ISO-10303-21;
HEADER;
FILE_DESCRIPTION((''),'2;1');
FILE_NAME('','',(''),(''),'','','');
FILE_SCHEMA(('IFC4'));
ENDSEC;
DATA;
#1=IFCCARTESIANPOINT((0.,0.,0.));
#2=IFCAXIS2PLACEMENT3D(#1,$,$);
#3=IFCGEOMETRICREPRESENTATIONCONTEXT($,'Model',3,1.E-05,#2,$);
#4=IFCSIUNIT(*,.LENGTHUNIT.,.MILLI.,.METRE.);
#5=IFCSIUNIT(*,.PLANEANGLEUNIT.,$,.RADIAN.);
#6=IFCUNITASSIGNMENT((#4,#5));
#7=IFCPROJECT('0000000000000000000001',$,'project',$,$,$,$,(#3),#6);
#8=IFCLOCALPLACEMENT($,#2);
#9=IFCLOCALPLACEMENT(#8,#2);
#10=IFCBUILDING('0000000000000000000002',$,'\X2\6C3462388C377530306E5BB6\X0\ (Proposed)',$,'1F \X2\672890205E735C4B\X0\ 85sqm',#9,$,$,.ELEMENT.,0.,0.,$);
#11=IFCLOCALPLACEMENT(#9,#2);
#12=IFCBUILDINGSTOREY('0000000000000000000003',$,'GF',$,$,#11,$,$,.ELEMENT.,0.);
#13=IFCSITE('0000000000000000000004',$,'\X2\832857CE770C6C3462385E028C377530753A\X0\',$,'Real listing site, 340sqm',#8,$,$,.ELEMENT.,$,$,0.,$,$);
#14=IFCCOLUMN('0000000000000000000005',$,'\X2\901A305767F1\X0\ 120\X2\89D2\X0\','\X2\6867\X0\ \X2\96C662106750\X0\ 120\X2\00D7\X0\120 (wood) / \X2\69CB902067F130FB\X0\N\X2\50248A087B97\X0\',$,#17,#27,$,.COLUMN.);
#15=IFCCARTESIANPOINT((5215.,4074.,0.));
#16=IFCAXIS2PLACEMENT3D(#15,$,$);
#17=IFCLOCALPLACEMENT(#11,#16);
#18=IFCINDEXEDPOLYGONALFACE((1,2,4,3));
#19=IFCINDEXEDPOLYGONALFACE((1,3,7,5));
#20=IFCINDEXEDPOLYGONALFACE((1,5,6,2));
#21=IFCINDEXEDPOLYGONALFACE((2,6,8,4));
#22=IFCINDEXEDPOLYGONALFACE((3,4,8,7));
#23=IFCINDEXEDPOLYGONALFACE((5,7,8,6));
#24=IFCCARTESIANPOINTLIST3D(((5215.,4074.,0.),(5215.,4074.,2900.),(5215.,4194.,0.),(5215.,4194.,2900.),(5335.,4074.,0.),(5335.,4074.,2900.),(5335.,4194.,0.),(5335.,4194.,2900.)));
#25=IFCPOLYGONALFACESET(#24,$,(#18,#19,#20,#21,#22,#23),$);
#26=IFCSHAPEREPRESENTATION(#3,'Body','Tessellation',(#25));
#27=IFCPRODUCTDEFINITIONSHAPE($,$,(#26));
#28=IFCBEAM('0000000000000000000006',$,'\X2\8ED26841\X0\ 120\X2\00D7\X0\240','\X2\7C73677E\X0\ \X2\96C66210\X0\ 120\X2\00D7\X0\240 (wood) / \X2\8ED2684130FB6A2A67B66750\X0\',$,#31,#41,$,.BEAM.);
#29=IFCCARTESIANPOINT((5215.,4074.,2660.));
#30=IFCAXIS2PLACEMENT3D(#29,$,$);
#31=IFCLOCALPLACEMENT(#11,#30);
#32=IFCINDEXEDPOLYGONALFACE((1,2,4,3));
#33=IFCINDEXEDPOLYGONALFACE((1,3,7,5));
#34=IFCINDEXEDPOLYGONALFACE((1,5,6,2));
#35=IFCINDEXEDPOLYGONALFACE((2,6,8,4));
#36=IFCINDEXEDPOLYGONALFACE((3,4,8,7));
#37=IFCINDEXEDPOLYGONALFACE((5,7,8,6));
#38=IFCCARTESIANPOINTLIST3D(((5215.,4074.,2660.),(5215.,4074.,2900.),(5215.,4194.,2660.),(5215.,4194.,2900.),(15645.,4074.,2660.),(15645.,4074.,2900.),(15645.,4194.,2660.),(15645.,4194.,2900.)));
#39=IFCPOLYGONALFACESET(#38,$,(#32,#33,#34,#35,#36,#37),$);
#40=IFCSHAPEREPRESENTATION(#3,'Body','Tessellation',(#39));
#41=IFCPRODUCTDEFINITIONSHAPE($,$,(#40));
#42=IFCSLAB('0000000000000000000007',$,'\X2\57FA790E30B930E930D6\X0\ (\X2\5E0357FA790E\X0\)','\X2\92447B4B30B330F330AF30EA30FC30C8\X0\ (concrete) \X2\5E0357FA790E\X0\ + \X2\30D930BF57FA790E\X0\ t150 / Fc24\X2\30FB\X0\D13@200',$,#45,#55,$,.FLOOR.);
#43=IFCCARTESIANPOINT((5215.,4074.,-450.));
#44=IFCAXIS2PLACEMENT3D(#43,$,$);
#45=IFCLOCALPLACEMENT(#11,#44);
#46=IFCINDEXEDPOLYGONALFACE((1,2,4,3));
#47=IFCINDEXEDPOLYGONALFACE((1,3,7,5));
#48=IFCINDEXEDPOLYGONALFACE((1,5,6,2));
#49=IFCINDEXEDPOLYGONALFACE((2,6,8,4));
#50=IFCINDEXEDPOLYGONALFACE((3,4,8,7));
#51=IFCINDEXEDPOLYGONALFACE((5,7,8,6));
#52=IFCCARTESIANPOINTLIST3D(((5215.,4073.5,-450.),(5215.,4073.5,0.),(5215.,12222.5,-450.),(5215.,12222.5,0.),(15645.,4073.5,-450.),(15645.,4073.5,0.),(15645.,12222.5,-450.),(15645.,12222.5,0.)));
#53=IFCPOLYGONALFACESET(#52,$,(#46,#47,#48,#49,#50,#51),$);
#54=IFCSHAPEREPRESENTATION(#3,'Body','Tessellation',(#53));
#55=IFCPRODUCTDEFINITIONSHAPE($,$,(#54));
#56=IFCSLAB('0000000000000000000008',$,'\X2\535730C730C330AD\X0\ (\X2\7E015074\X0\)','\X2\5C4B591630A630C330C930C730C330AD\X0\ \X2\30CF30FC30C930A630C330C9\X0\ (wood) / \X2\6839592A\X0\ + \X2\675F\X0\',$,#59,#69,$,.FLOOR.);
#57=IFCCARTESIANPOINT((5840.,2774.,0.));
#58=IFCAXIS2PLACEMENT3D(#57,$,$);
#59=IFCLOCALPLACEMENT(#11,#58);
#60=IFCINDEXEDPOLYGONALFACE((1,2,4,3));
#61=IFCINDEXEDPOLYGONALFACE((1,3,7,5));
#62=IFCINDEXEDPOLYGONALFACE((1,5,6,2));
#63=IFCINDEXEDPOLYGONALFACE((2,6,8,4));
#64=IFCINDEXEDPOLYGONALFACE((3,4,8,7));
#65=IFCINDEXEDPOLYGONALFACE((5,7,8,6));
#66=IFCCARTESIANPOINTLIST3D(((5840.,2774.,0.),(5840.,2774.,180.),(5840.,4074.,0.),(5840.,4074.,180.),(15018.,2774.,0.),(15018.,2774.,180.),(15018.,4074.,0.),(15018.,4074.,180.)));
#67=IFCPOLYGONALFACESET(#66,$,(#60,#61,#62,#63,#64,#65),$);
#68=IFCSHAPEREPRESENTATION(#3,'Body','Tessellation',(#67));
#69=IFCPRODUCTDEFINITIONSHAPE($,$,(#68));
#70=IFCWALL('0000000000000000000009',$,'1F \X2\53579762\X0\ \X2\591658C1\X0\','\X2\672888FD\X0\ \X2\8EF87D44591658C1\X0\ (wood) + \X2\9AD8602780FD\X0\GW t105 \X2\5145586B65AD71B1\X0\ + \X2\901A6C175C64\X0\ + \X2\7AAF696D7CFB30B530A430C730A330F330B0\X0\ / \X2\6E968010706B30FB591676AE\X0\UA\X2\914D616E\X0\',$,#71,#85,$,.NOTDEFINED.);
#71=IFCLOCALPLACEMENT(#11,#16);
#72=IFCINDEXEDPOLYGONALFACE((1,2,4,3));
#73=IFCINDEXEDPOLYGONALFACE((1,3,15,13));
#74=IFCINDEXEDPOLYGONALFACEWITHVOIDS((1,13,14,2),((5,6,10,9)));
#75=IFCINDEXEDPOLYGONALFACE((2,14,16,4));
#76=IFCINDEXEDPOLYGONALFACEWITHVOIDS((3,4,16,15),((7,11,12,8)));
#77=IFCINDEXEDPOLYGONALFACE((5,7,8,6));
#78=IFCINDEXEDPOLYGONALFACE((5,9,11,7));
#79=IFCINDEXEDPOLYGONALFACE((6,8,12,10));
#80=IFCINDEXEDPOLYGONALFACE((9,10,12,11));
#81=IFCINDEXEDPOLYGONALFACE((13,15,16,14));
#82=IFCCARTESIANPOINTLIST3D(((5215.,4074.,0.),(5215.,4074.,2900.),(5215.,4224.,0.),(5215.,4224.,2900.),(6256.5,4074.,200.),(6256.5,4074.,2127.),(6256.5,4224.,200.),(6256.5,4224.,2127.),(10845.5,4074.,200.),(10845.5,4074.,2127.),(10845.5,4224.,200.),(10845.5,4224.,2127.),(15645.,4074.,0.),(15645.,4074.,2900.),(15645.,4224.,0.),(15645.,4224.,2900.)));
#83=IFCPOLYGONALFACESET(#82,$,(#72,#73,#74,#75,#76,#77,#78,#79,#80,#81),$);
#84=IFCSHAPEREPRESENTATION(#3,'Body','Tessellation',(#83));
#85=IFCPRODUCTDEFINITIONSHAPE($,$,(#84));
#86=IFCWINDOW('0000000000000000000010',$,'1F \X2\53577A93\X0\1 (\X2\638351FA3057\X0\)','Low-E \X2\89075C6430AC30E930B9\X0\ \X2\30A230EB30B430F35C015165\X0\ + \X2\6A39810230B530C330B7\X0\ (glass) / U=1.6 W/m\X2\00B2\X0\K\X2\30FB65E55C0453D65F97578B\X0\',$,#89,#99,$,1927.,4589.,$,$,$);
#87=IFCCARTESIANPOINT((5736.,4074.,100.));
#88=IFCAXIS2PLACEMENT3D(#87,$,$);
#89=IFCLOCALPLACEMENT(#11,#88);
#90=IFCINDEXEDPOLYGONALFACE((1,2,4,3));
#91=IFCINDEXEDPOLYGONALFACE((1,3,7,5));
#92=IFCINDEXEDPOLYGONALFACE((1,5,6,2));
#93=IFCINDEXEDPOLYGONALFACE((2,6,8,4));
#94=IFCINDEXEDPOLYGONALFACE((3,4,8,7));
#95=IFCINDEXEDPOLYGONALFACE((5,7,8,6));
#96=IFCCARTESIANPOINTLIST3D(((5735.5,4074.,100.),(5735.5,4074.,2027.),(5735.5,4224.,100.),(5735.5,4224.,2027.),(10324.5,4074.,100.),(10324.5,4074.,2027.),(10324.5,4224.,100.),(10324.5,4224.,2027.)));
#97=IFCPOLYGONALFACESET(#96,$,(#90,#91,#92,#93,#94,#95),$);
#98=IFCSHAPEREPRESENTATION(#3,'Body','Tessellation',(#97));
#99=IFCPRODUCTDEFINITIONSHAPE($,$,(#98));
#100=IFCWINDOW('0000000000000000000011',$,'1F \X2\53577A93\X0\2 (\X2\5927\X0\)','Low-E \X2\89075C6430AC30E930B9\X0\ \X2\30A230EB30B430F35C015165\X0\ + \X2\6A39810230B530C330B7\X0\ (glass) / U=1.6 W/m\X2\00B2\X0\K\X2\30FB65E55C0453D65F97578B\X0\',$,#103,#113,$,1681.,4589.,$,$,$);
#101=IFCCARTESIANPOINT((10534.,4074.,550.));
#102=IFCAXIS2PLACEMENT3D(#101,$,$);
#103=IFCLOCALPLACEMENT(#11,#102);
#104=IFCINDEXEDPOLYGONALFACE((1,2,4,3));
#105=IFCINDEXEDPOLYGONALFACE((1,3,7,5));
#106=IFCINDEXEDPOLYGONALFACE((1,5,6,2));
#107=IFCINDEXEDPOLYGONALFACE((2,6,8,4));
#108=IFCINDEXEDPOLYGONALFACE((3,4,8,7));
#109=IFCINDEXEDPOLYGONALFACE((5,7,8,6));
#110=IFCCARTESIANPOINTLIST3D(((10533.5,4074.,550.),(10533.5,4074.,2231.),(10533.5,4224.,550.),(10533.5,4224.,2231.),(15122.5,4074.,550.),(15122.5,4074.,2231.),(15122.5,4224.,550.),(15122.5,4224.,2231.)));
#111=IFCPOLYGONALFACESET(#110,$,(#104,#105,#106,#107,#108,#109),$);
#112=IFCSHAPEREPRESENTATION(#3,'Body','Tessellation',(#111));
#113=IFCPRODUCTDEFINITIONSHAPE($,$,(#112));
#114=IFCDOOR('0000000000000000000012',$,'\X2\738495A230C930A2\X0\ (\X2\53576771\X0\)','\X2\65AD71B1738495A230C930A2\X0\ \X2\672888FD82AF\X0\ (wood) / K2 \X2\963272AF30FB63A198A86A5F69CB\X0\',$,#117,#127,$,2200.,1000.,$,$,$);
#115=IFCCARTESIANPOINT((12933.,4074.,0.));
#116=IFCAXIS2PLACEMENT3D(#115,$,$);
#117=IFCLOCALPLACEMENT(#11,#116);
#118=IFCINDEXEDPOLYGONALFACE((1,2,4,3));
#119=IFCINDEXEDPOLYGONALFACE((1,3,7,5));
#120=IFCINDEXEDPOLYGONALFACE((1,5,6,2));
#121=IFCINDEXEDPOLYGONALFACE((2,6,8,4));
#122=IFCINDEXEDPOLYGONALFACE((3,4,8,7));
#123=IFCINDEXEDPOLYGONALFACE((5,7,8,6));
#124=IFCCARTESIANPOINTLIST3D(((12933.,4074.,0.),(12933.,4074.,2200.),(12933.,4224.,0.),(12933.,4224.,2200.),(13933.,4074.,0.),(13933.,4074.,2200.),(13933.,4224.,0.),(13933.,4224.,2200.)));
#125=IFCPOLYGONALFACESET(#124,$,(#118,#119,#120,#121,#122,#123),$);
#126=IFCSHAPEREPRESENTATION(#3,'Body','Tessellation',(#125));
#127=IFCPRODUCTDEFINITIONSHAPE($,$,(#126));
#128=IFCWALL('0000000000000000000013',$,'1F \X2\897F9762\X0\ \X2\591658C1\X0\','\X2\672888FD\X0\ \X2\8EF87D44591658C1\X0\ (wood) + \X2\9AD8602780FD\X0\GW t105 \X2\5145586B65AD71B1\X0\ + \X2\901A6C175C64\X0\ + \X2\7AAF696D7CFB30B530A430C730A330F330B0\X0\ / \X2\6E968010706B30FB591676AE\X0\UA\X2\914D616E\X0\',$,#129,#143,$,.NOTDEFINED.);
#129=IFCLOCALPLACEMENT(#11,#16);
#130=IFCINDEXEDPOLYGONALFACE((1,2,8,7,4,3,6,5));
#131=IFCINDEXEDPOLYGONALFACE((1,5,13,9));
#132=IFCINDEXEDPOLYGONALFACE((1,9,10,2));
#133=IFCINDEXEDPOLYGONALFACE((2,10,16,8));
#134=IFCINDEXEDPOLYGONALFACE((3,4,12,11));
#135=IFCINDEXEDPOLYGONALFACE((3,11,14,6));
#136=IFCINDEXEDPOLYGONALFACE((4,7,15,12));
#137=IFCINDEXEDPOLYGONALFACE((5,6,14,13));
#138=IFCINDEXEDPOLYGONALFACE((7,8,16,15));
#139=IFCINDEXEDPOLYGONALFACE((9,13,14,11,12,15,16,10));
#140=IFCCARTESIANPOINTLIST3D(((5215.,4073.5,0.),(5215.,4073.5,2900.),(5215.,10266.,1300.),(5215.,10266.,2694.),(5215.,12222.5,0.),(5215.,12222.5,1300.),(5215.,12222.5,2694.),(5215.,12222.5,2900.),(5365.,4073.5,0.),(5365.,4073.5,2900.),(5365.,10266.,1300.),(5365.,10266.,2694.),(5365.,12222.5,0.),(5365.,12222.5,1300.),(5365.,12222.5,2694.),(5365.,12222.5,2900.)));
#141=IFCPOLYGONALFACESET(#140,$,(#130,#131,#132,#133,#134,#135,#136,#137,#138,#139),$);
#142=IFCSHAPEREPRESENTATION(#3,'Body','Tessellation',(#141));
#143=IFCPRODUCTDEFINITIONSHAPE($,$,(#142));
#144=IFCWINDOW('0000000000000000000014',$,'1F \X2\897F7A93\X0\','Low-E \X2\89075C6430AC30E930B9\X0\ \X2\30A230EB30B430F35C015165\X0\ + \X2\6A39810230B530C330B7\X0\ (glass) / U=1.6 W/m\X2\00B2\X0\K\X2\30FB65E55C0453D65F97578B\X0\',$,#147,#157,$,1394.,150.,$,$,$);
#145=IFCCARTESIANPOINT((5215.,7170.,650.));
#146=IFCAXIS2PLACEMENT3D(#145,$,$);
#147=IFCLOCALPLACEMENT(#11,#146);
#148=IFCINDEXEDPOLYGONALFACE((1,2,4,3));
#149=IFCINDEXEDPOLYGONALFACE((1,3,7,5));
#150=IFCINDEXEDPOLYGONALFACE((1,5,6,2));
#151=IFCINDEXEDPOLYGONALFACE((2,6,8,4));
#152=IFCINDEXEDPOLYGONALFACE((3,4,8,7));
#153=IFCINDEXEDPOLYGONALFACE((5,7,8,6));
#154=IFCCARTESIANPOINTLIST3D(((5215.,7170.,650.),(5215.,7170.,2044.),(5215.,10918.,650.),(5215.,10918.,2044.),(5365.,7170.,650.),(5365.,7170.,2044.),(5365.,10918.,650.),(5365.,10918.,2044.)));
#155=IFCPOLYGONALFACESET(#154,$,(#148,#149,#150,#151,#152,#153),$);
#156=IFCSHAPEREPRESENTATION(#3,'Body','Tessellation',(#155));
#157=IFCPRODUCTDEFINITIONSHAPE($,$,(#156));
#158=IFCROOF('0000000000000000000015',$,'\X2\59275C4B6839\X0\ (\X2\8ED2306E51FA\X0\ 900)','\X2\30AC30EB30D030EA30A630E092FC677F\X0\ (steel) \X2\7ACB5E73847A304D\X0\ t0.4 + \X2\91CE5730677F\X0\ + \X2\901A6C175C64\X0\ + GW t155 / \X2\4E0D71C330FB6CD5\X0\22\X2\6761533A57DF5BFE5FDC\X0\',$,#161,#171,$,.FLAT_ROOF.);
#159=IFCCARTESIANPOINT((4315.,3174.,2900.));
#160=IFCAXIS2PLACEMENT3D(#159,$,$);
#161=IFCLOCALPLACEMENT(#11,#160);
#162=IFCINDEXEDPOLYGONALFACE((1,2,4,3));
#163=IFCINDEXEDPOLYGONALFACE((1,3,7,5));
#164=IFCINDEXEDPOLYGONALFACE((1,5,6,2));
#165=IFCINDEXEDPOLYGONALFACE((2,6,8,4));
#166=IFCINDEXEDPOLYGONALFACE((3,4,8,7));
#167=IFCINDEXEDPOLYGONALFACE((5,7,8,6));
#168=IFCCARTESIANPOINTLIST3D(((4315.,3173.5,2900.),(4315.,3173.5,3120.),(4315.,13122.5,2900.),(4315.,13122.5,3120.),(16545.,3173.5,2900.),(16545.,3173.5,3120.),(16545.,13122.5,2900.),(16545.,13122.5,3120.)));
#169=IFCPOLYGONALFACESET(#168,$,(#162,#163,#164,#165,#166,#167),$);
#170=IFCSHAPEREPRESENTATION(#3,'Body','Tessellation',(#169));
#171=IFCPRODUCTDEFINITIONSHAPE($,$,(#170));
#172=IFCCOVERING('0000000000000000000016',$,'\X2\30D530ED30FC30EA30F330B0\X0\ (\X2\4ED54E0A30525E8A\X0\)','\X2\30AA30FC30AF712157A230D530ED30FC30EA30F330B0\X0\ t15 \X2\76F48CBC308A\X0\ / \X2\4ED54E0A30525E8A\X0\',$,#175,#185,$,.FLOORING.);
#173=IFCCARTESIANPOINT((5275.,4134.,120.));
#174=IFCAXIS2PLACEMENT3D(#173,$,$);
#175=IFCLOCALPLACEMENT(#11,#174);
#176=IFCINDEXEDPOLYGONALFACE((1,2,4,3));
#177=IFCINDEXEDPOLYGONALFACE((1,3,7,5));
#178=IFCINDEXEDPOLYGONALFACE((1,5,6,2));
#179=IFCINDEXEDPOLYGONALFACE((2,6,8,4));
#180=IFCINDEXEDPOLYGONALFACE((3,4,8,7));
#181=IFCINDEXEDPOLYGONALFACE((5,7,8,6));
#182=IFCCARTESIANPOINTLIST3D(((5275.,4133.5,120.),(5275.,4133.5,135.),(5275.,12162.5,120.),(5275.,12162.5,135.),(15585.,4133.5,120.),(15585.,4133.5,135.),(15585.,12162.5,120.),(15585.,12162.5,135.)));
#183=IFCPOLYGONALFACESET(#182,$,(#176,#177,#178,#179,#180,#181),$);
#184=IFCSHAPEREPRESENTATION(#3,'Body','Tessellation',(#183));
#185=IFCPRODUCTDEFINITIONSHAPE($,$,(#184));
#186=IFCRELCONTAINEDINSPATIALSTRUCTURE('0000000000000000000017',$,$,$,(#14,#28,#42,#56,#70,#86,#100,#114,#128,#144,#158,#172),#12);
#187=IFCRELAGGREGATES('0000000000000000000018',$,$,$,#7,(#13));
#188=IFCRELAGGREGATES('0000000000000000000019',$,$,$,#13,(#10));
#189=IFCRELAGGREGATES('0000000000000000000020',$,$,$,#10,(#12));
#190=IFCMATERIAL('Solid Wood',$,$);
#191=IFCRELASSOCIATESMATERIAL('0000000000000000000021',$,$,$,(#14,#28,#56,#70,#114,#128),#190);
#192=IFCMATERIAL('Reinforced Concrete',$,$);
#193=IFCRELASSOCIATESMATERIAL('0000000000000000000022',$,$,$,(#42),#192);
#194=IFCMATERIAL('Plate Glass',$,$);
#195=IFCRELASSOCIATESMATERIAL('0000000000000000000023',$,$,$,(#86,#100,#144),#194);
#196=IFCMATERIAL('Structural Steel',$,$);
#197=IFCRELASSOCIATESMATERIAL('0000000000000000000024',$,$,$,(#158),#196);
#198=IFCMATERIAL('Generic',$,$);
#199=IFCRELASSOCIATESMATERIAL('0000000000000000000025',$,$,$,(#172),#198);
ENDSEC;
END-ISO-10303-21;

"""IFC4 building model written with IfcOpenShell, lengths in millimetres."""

from ifc_helpers import new_model, si_unit, frame, frame_2d, origin, place, context, project, spatial, rectangle, extrude, material, element, fill, save


model = new_model("IFC4")

# Units and contexts
model_context = context("Model", 3, precision=1e-05, world=origin())
ifc_project = project(units=[si_unit("LENGTHUNIT", "METRE", prefix="MILLI"), si_unit("PLANEANGLEUNIT", "RADIAN")], contexts=[model_context])

# Site, building, storey
site_placement = place(None, origin())
site = spatial("IfcSite", under=ifc_project, at=site_placement, Name="茨城県水戸市谷田町", ObjectType="Real listing site, 340sqm", CompositionType="ELEMENT", RefElevation=0.0)
building_placement = place(site_placement, origin())
building = spatial("IfcBuilding", under=site, at=building_placement, Name="水戸谷田の家 (Proposed)", ObjectType="1F 木造平屋 85sqm", CompositionType="ELEMENT", ElevationOfRefHeight=0.0, ElevationOfTerrain=0.0)
storey_placement = place(building_placement, origin())
storey = spatial("IfcBuildingStorey", under=building, at=storey_placement, Name="GF", CompositionType="ELEMENT", Elevation=0.0)

# Column
ifc_material_1 = material(Name="Solid Wood")
column_1_placement = place(storey_placement, frame((5215.0, 4074.0, 0.0)))
element("IfcColumn", 1, at=column_1_placement, inside=storey, material=ifc_material_1, Name="通し柱 120角", Description="桧 集成材 120×120 (wood) / 構造柱・N値計算", PredefinedType="COLUMN", context=model_context, shape_type="SweptSolid", body=[
    extrude(rectangle(XDim=120.0, YDim=120.0, at=frame_2d((60.0, 60.0))), frame((5215.0, 4074.0, 0.0)), (0.0, 0.0, 1.0), 2900.0),
])

# Beam
beam_1_placement = place(storey_placement, frame((5215.0, 4074.0, 2660.0)))
element("IfcBeam", 2, at=beam_1_placement, inside=storey, material=ifc_material_1, Name="軒桁 120×240", Description="米松 集成 120×240 (wood) / 軒桁・横架材", PredefinedType="BEAM", context=model_context, shape_type="SweptSolid", body=[
    extrude(rectangle(XDim=10430.0, YDim=120.0, at=frame_2d((5215.0, 60.0))), frame((5215.0, 4074.0, 2660.0)), (0.0, 0.0, 1.0), 240.0),
])

# Slabs
ifc_material_2 = material(Name="Reinforced Concrete")
slab_1_placement = place(storey_placement, frame((5215.0, 4074.0, -450.0)))
element("IfcSlab", 3, at=slab_1_placement, inside=storey, material=ifc_material_2, Name="基礎スラブ (布基礎)", Description="鉄筋コンクリート (concrete) 布基礎 + ベタ基礎 t150 / Fc24・D13@200", PredefinedType="FLOOR", context=model_context, shape_type="SweptSolid", body=[
    extrude(rectangle(XDim=10430.0, YDim=8149.0, at=frame_2d((5215.0, 4074.0))), frame((5215.0, 4074.0, -450.0)), (0.0, 0.0, 1.0), 450.0),
])
slab_2_placement = place(storey_placement, frame((5840.0, 2774.0, 0.0)))
element("IfcSlab", 4, at=slab_2_placement, inside=storey, material=ifc_material_1, Name="南デッキ (縁側)", Description="屋外ウッドデッキ ハードウッド (wood) / 根太 + 束", PredefinedType="FLOOR", context=model_context, shape_type="SweptSolid", body=[
    extrude(rectangle(XDim=9178.0, YDim=1300.0, at=frame_2d((4589.0, 650.0))), frame((5840.0, 2774.0, 0.0)), (0.0, 0.0, 1.0), 180.0),
])

# Wall, openings, windows, door
wall_1_placement = place(storey_placement, frame((5215.0, 4074.0, 0.0)))
wall_1 = element("IfcWall", 5, at=wall_1_placement, inside=storey, material=ifc_material_1, Name="1F 南面 外壁", Description="木製 軸組外壁 (wood) + 高性能GW t105 充填断熱 + 通気層 + 窯業系サイディング / 準耐火・外皮UA配慮", PredefinedType="NOTDEFINED", context=model_context, shape_type="SweptSolid", body=[
    extrude(rectangle(XDim=10430.0, YDim=150.0, at=frame_2d((5215.0, 75.0))), frame((5215.0, 4074.0, 0.0)), (0.0, 0.0, 1.0), 2900.0),
])
opening_1_placement = place(storey_placement, frame((5736.0, 4074.0, 100.0)))
opening_1 = element("IfcOpeningElement", 6, at=opening_1_placement, cuts=wall_1, PredefinedType="NOTDEFINED", context=model_context, shape_type="SweptSolid", body=[
    extrude(rectangle(XDim=4589.0, YDim=150.0, at=frame_2d((2294.0, 75.0))), frame((5736.0, 4074.0, 100.0)), (0.0, 0.0, 1.0), 1927.0),
])
opening_2_placement = place(storey_placement, frame((10534.0, 4074.0, 550.0)))
opening_2 = element("IfcOpeningElement", 7, at=opening_2_placement, cuts=wall_1, PredefinedType="NOTDEFINED", context=model_context, shape_type="SweptSolid", body=[
    extrude(rectangle(XDim=4589.0, YDim=150.0, at=frame_2d((2294.0, 75.0))), frame((10534.0, 4074.0, 550.0)), (0.0, 0.0, 1.0), 1681.0),
])
opening_3_placement = place(storey_placement, frame((12933.0, 4074.0, 0.0)))
opening_3 = element("IfcOpeningElement", 8, at=opening_3_placement, cuts=wall_1, PredefinedType="NOTDEFINED", context=model_context, shape_type="SweptSolid", body=[
    extrude(rectangle(XDim=1000.0, YDim=150.0, at=frame_2d((500.0, 75.0))), frame((12933.0, 4074.0, 0.0)), (0.0, 0.0, 1.0), 2200.0),
])
ifc_material_3 = material(Name="Plate Glass")
window_1_placement = place(storey_placement, frame((5736.0, 4074.0, 100.0)))
window_1 = element("IfcWindow", 9, at=window_1_placement, inside=storey, material=ifc_material_3, Name="1F 南窓1 (掃出し)", Description="Low-E 複層ガラス アルゴン封入 + 樹脂サッシ (glass) / U=1.6 W/m²K・日射取得型", OverallHeight=1927.0, OverallWidth=4589.0, context=model_context, shape_type="SweptSolid", body=[
    extrude(rectangle(XDim=4589.0, YDim=150.0, at=frame_2d((2294.0, 75.0))), frame((5736.0, 4074.0, 100.0)), (0.0, 0.0, 1.0), 1927.0),
])
fill(opening_1, window_1)
window_2_placement = place(storey_placement, frame((10534.0, 4074.0, 550.0)))
window_2 = element("IfcWindow", 10, at=window_2_placement, inside=storey, material=ifc_material_3, Name="1F 南窓2 (大)", Description="Low-E 複層ガラス アルゴン封入 + 樹脂サッシ (glass) / U=1.6 W/m²K・日射取得型", OverallHeight=1681.0, OverallWidth=4589.0, context=model_context, shape_type="SweptSolid", body=[
    extrude(rectangle(XDim=4589.0, YDim=150.0, at=frame_2d((2294.0, 75.0))), frame((10534.0, 4074.0, 550.0)), (0.0, 0.0, 1.0), 1681.0),
])
fill(opening_2, window_2)
door_placement = place(storey_placement, frame((12933.0, 4074.0, 0.0)))
door = element("IfcDoor", 11, at=door_placement, inside=storey, material=ifc_material_1, Name="玄関ドア (南東)", Description="断熱玄関ドア 木製芯 (wood) / K2 防犯・採風機構", OverallHeight=2200.0, OverallWidth=1000.0, context=model_context, shape_type="SweptSolid", body=[
    extrude(rectangle(XDim=1000.0, YDim=150.0, at=frame_2d((500.0, 75.0))), frame((12933.0, 4074.0, 0.0)), (0.0, 0.0, 1.0), 2200.0),
])
fill(opening_3, door)

# Wall, opening, window
wall_2_placement = place(storey_placement, frame((5215.0, 4074.0, 0.0)))
wall_2 = element("IfcWall", 12, at=wall_2_placement, inside=storey, material=ifc_material_1, Name="1F 西面 外壁", Description="木製 軸組外壁 (wood) + 高性能GW t105 充填断熱 + 通気層 + 窯業系サイディング / 準耐火・外皮UA配慮", PredefinedType="NOTDEFINED", context=model_context, shape_type="SweptSolid", body=[
    extrude(rectangle(XDim=150.0, YDim=8149.0, at=frame_2d((75.0, 4074.0))), frame((5215.0, 4074.0, 0.0)), (0.0, 0.0, 1.0), 2900.0),
])
opening_4_placement = place(storey_placement, frame((5215.0, 7170.0, 650.0)))
opening_4 = element("IfcOpeningElement", 13, at=opening_4_placement, cuts=wall_2, PredefinedType="NOTDEFINED", context=model_context, shape_type="SweptSolid", body=[
    extrude(rectangle(XDim=150.0, YDim=3748.0, at=frame_2d((75.0, 1874.0))), frame((5215.0, 7170.0, 650.0)), (0.0, 0.0, 1.0), 1394.0),
])
window_3_placement = place(storey_placement, frame((5215.0, 7170.0, 650.0)))
window_3 = element("IfcWindow", 14, at=window_3_placement, inside=storey, material=ifc_material_3, Name="1F 西窓", Description="Low-E 複層ガラス アルゴン封入 + 樹脂サッシ (glass) / U=1.6 W/m²K・日射取得型", OverallHeight=1394.0, OverallWidth=150.0, context=model_context, shape_type="SweptSolid", body=[
    extrude(rectangle(XDim=150.0, YDim=3748.0, at=frame_2d((75.0, 1874.0))), frame((5215.0, 7170.0, 650.0)), (0.0, 0.0, 1.0), 1394.0),
])
fill(opening_4, window_3)

# Roof
ifc_material_4 = material(Name="Structural Steel")
roof_placement = place(storey_placement, frame((4315.0, 3174.0, 2900.0)))
element("IfcRoof", 15, at=roof_placement, inside=storey, material=ifc_material_4, Name="大屋根 (軒の出 900)", Description="ガルバリウム鋼板 (steel) 立平葺き t0.4 + 野地板 + 通気層 + GW t155 / 不燃・法22条区域対応", PredefinedType="FLAT_ROOF", context=model_context, shape_type="SweptSolid", body=[
    extrude(rectangle(XDim=12230.0, YDim=9949.0, at=frame_2d((6115.0, 4974.0))), frame((4315.0, 3174.0, 2900.0)), (0.0, 0.0, 1.0), 220.0),
])

# Covering
ifc_material_5 = material(Name="Generic")
covering_1_placement = place(storey_placement, frame((5275.0, 4134.0, 120.0)))
element("IfcCovering", 16, at=covering_1_placement, inside=storey, material=ifc_material_5, Name="フローリング (仕上げ床)", Description="オーク無垢フローリング t15 直貼り / 仕上げ床", PredefinedType="FLOORING", context=model_context, shape_type="SweptSolid", body=[
    extrude(rectangle(XDim=10310.0, YDim=8029.0, at=frame_2d((5155.0, 4014.0))), frame((5275.0, 4134.0, 120.0)), (0.0, 0.0, 1.0), 15.0),
])

save(model, "model.ifc")
